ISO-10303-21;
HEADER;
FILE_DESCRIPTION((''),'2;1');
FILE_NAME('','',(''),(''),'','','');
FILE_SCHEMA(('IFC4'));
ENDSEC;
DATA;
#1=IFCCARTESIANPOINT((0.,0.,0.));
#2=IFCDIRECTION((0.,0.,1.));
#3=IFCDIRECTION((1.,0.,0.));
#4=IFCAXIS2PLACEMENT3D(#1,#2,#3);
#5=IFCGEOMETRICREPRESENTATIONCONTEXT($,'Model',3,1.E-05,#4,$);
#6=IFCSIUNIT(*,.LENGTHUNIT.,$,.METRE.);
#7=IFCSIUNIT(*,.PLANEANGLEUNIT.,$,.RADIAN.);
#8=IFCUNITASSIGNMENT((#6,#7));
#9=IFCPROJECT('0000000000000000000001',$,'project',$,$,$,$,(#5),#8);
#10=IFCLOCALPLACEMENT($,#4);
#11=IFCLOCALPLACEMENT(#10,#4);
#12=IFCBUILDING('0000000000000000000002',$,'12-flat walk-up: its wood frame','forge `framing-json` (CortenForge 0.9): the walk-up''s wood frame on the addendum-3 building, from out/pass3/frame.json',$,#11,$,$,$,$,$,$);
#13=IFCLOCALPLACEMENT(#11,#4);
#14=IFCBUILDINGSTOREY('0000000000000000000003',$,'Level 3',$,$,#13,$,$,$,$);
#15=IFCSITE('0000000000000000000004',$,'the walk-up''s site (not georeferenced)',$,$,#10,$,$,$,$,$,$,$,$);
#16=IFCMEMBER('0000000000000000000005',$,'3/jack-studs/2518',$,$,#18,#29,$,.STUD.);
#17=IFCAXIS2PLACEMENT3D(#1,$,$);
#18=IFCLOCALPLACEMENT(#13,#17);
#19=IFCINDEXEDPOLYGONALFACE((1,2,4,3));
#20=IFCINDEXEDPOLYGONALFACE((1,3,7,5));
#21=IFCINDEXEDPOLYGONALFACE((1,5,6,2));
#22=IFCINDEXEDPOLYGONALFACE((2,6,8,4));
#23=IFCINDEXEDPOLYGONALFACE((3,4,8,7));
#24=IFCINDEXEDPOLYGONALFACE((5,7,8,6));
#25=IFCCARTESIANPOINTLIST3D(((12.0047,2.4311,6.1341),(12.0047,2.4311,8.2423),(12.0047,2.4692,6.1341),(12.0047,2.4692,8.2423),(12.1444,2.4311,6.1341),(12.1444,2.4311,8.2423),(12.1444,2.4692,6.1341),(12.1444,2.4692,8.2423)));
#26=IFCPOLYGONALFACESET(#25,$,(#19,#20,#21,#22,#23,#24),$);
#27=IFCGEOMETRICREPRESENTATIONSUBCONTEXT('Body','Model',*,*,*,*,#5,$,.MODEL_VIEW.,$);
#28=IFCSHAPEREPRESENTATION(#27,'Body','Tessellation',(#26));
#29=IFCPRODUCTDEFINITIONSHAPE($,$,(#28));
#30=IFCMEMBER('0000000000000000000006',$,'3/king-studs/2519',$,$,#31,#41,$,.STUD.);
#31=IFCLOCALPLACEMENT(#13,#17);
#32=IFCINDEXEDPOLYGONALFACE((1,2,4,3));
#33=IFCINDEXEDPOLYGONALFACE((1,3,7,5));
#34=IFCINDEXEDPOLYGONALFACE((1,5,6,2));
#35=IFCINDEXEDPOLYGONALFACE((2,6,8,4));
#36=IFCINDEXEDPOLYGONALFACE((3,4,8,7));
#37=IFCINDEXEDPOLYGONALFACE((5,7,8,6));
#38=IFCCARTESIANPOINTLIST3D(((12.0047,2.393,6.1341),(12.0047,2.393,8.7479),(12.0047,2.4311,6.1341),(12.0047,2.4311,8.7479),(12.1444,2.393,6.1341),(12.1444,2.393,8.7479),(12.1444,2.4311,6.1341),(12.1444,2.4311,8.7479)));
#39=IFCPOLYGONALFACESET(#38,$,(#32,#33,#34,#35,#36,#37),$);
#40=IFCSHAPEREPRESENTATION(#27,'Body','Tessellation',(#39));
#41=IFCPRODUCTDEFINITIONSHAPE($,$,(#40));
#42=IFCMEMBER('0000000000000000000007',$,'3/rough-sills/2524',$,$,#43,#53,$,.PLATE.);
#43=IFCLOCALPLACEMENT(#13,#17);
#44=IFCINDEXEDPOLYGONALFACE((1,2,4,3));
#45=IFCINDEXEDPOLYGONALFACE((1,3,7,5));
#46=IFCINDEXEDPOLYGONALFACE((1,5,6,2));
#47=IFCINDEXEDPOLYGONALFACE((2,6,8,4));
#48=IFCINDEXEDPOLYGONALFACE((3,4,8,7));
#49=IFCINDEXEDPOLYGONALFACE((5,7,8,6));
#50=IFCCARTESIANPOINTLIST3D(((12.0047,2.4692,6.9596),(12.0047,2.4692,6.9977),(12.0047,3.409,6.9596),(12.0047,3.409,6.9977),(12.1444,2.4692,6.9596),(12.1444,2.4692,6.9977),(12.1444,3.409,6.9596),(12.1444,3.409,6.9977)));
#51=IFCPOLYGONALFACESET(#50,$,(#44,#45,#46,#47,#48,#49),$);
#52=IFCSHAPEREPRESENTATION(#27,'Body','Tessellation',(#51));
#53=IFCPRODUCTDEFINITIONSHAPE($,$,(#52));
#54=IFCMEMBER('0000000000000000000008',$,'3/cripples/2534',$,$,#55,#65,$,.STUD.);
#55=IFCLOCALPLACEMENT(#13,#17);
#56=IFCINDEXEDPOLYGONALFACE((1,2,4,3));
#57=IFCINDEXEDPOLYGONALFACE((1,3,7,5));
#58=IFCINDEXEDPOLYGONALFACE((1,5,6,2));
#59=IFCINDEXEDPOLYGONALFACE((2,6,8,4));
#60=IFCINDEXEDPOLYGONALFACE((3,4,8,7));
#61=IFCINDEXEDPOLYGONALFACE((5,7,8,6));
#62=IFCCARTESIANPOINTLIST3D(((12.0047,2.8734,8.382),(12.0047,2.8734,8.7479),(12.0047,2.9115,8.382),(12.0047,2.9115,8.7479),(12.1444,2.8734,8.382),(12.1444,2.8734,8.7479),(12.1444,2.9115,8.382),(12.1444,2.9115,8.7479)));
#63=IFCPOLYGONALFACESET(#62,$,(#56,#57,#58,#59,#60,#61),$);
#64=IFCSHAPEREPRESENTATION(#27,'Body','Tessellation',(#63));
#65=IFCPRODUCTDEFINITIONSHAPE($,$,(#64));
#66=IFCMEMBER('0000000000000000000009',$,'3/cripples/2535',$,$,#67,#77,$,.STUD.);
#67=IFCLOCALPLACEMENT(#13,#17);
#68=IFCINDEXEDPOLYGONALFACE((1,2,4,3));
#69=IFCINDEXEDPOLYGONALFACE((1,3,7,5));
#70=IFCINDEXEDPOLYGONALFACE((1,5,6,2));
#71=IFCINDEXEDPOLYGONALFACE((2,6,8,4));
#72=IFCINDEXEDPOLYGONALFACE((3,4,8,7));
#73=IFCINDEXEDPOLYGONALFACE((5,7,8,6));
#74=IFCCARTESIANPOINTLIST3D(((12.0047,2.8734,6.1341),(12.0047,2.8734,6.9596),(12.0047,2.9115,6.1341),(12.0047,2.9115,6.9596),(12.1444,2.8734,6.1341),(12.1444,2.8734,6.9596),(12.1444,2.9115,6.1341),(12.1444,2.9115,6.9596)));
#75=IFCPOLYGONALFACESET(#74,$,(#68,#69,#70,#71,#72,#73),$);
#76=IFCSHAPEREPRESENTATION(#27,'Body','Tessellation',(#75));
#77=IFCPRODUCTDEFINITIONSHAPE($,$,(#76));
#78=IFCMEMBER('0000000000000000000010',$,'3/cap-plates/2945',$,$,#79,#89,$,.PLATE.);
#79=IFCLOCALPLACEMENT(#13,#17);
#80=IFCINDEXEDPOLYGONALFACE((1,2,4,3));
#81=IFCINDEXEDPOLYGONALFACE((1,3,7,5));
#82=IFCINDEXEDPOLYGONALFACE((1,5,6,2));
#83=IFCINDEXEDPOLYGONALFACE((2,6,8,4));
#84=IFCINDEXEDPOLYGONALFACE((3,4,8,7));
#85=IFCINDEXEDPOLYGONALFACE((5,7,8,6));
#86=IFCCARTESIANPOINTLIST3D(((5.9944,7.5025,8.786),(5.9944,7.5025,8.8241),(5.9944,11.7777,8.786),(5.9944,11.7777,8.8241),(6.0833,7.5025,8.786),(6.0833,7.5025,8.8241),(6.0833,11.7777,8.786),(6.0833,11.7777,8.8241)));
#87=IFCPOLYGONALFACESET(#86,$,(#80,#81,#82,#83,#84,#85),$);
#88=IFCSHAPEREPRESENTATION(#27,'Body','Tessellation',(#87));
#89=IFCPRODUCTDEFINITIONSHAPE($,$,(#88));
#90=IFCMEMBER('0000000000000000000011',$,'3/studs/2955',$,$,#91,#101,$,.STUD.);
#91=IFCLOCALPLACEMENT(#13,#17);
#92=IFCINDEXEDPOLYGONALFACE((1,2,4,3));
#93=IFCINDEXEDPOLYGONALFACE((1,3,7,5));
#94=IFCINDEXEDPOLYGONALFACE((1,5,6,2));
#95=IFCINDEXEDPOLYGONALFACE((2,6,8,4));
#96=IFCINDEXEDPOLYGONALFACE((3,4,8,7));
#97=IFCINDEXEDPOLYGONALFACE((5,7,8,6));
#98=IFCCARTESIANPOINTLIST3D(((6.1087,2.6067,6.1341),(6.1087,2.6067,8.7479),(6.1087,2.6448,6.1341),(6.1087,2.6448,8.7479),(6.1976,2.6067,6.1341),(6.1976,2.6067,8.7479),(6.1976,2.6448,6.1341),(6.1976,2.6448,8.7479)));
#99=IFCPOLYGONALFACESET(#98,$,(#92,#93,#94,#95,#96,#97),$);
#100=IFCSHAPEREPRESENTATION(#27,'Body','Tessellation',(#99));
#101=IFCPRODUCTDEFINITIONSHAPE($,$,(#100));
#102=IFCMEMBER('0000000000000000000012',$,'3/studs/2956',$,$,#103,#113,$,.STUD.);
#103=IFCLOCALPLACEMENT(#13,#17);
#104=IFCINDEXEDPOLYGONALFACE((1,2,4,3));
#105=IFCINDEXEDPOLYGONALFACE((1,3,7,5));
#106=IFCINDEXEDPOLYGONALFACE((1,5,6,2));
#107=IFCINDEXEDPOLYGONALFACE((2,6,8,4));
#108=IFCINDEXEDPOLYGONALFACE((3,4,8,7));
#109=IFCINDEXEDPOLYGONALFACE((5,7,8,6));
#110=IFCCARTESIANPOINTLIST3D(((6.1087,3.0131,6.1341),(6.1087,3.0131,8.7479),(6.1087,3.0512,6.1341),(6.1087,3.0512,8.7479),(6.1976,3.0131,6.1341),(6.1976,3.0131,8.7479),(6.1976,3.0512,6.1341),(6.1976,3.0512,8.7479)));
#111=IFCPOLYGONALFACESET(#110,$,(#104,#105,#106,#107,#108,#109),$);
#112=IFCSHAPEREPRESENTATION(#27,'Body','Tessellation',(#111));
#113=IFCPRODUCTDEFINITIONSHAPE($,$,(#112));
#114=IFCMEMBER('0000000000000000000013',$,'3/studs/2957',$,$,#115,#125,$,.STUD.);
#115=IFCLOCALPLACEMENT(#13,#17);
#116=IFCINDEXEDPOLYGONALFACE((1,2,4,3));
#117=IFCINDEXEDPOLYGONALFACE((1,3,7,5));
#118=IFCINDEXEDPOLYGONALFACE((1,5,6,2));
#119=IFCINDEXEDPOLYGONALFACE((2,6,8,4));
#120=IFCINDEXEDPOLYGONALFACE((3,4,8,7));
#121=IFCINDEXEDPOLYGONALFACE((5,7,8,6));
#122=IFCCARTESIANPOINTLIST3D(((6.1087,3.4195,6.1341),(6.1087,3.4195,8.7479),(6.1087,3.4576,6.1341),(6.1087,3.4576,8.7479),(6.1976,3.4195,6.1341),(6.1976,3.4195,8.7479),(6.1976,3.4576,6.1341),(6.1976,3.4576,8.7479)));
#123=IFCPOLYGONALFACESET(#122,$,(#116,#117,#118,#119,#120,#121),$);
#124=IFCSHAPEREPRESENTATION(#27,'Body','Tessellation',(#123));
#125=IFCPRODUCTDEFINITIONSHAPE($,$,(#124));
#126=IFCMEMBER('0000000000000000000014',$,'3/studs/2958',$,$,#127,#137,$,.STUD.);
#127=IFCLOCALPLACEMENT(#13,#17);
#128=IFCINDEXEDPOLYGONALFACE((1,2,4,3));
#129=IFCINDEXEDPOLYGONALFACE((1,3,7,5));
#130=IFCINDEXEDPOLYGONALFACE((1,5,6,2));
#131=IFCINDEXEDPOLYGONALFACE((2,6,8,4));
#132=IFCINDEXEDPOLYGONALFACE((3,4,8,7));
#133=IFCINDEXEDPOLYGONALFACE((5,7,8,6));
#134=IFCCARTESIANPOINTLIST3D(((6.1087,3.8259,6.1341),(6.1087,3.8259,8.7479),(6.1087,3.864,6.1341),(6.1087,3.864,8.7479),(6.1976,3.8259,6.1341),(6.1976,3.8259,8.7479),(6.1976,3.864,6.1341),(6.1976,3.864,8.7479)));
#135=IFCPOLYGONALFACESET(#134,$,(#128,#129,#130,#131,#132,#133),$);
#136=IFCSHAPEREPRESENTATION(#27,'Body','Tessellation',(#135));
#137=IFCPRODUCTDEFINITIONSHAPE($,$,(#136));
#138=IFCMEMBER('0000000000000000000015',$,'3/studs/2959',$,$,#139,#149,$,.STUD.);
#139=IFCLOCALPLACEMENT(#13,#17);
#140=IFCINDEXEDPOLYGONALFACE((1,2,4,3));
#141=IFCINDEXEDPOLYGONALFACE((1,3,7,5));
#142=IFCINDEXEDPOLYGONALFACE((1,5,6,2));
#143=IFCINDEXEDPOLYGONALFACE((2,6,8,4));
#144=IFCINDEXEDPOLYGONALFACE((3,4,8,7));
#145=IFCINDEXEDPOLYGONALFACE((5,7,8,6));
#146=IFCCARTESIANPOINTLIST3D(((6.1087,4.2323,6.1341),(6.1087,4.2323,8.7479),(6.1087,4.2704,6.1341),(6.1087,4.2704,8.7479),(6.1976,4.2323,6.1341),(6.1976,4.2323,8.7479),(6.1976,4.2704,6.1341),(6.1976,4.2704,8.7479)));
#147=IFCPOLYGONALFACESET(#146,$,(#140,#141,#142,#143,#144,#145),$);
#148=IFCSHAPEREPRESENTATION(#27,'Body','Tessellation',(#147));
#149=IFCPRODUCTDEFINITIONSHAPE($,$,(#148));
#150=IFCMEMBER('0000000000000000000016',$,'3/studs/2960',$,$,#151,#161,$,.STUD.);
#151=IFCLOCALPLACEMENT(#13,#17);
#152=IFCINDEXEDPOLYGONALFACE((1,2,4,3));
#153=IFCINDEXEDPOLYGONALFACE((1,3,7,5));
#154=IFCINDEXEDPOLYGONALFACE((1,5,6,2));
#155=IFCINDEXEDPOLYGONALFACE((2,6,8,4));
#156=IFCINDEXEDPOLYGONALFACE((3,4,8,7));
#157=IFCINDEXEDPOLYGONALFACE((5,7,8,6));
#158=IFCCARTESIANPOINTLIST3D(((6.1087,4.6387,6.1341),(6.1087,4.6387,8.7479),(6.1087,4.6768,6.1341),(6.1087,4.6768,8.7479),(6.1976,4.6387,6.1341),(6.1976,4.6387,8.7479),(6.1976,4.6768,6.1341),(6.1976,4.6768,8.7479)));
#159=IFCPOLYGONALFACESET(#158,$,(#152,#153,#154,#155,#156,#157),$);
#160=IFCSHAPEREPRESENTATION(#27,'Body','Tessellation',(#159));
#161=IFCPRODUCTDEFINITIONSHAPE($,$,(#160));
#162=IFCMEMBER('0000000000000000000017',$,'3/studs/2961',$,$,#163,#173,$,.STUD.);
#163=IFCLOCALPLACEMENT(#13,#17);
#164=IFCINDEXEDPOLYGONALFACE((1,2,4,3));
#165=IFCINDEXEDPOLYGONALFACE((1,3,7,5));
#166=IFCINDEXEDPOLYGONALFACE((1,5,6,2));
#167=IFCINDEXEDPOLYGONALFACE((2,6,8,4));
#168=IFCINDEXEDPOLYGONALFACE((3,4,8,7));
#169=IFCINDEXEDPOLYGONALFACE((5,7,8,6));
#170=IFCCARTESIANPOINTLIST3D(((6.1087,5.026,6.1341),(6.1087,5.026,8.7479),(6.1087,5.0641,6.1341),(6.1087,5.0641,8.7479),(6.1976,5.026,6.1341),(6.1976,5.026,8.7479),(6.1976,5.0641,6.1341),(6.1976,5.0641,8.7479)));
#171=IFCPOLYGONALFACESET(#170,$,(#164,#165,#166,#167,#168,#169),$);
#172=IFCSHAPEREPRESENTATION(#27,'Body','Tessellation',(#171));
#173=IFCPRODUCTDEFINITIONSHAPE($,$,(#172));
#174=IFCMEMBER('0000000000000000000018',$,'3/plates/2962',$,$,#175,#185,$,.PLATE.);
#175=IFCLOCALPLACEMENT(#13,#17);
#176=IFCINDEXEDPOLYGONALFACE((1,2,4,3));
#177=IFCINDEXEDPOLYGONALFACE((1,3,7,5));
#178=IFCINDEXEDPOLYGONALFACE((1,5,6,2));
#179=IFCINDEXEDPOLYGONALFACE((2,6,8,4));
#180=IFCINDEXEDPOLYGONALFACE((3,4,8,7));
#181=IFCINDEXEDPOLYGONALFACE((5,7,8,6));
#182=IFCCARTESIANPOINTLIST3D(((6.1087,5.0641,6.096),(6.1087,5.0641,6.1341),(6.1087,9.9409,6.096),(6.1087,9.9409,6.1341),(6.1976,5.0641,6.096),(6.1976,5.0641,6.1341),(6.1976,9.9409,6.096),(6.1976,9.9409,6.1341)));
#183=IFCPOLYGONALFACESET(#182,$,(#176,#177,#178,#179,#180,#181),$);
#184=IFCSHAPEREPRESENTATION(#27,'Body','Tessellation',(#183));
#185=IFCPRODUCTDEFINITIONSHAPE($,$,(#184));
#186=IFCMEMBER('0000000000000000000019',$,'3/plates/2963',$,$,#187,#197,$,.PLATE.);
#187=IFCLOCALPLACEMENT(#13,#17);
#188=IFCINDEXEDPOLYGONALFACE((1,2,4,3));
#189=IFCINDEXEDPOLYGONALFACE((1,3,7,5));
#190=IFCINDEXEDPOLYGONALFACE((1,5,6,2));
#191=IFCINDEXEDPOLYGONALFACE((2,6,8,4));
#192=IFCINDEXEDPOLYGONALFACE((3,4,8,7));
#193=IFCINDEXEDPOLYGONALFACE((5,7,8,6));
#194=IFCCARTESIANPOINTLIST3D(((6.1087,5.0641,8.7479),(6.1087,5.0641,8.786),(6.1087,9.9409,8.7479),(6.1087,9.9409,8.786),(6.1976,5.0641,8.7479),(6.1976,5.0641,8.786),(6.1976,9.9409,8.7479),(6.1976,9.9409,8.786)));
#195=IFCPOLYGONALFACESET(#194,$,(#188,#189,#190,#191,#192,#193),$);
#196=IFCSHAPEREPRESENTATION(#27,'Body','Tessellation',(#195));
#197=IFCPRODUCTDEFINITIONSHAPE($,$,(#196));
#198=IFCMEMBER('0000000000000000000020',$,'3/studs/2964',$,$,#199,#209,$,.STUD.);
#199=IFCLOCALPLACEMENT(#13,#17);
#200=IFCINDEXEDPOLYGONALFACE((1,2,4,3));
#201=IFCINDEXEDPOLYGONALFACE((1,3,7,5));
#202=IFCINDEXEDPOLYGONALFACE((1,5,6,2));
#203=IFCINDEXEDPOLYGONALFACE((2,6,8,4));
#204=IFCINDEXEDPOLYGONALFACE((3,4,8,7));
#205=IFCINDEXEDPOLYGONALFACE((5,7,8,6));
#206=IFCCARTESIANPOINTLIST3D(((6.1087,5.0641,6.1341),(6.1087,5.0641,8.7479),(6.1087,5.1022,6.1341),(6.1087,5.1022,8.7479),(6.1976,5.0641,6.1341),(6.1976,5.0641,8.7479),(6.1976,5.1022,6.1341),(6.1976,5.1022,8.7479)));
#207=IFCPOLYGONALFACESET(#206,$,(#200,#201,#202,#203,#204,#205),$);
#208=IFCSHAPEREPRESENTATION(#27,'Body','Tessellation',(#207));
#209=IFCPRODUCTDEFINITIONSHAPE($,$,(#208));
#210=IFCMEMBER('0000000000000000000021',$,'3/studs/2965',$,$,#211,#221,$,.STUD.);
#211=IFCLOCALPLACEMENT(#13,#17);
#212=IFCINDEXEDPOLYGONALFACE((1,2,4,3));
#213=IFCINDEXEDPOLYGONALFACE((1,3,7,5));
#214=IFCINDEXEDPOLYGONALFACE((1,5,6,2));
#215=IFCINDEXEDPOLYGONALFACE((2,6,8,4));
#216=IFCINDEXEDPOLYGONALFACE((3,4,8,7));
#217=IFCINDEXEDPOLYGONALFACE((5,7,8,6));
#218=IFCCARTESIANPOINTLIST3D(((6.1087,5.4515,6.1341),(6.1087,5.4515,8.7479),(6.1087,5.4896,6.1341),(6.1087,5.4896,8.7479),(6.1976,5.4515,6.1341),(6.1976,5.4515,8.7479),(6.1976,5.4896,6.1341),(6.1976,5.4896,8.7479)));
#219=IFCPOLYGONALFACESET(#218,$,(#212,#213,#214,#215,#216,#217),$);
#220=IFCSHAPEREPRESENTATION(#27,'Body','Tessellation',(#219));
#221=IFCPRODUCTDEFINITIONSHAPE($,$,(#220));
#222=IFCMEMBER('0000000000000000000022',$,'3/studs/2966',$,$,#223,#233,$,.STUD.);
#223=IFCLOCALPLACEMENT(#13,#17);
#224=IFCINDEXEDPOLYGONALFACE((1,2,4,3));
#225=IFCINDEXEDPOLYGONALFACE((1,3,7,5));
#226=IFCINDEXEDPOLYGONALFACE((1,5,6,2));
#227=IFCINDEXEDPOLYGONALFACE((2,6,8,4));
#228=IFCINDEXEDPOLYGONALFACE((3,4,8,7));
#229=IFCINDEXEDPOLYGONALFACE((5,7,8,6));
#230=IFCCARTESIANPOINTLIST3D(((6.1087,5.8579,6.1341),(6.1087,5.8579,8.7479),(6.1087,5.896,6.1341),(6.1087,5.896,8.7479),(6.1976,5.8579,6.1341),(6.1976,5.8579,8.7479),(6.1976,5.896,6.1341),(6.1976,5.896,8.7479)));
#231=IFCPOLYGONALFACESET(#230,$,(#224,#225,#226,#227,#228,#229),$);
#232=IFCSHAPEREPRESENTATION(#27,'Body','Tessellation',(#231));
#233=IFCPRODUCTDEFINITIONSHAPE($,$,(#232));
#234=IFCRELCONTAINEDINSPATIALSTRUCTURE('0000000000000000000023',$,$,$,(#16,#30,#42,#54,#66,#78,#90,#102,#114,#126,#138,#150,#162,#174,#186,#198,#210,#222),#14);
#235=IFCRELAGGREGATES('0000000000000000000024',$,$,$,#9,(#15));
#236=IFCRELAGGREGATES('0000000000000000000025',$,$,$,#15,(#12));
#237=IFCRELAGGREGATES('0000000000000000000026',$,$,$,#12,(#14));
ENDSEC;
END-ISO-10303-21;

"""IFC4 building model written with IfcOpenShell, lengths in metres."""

from ifc_helpers import new_model, si_unit, frame, frame_2d, origin, origin_with_axes, place, context, subcontext, project, spatial, rectangle, extrude, element, save


model = new_model("IFC4")

# Units and contexts
model_context = context("Model", 3, precision=1e-05, world=origin_with_axes())
body_context = subcontext(model_context, "Body", "Model", "MODEL_VIEW")
ifc_project = project(units=[si_unit("LENGTHUNIT", "METRE"), si_unit("PLANEANGLEUNIT", "RADIAN")], contexts=[model_context])

# Site, building, storey
site_placement = place(None, origin_with_axes())
site = spatial("IfcSite", under=ifc_project, at=site_placement, Name="the walk-up's site (not georeferenced)")
building_placement = place(site_placement, origin_with_axes())
building = spatial("IfcBuilding", under=site, at=building_placement, Name="12-flat walk-up: its wood frame", Description="forge `framing-json` (CortenForge 0.9): the walk-up's wood frame on the addendum-3 building, from out/pass3/frame.json")
storey_placement = place(building_placement, origin_with_axes())
storey = spatial("IfcBuildingStorey", under=building, at=storey_placement, Name="Level 3")

# Members
member_1_placement = place(storey_placement, frame((12.0047, 2.4311, 6.1341), z_axis=(0.0, 0.0, 1.0), x_axis=(1.0, 0.0, 0.0)))
element("IfcMember", 1, at=member_1_placement, inside=storey, Name="3/jack-studs/2518", PredefinedType="STUD", context=body_context, shape_type="SweptSolid", body=[
    extrude(rectangle(XDim=0.1397, YDim=0.0381, at=frame_2d((0.0698, 0.0191))), origin(), (0.0, 0.0, 1.0), 2.1082),
])
member_2_placement = place(storey_placement, frame((12.0047, 2.393, 6.1341), z_axis=(0.0, 0.0, 1.0), x_axis=(1.0, 0.0, 0.0)))
element("IfcMember", 2, at=member_2_placement, inside=storey, Name="3/king-studs/2519", PredefinedType="STUD", context=body_context, shape_type="SweptSolid", body=[
    extrude(rectangle(XDim=0.1397, YDim=0.0381, at=frame_2d((0.0698, 0.0191))), origin(), (0.0, 0.0, 1.0), 2.6138),
])
member_3_placement = place(storey_placement, frame((12.0047, 2.4692, 6.9596), z_axis=(0.0, 0.0, 1.0), x_axis=(1.0, 0.0, 0.0)))
element("IfcMember", 3, at=member_3_placement, inside=storey, Name="3/rough-sills/2524", PredefinedType="PLATE", context=body_context, shape_type="SweptSolid", body=[
    extrude(rectangle(XDim=0.1397, YDim=0.9398, at=frame_2d((0.0698, 0.4699))), origin(), (0.0, 0.0, 1.0), 0.0381),
])
member_4_placement = place(storey_placement, frame((12.0047, 2.8734, 8.382), z_axis=(0.0, 0.0, 1.0), x_axis=(1.0, 0.0, 0.0)))
element("IfcMember", 4, at=member_4_placement, inside=storey, Name="3/cripples/2534", PredefinedType="STUD", context=body_context, shape_type="SweptSolid", body=[
    extrude(rectangle(XDim=0.1397, YDim=0.0381, at=frame_2d((0.0698, 0.0191))), origin(), (0.0, 0.0, 1.0), 0.3659),
])
member_5_placement = place(storey_placement, frame((12.0047, 2.8734, 6.1341), z_axis=(0.0, 0.0, 1.0), x_axis=(1.0, 0.0, 0.0)))
element("IfcMember", 5, at=member_5_placement, inside=storey, Name="3/cripples/2535", PredefinedType="STUD", context=body_context, shape_type="SweptSolid", body=[
    extrude(rectangle(XDim=0.1397, YDim=0.0381, at=frame_2d((0.0698, 0.0191))), origin(), (0.0, 0.0, 1.0), 0.8255),
])
member_6_placement = place(storey_placement, frame((5.9944, 7.5025, 8.786), z_axis=(0.0, 0.0, 1.0), x_axis=(1.0, 0.0, 0.0)))
element("IfcMember", 6, at=member_6_placement, inside=storey, Name="3/cap-plates/2945", PredefinedType="PLATE", context=body_context, shape_type="SweptSolid", body=[
    extrude(rectangle(XDim=0.0889, YDim=4.2751, at=frame_2d((0.0445, 2.1376))), origin(), (0.0, 0.0, 1.0), 0.0381),
])
for number, where, z_axis, x_axis, name in (
    (7, (6.1087, 2.6067, 6.1341), (0.0, 0.0, 1.0), (1.0, 0.0, 0.0), "3/studs/2955"),
    (8, (6.1087, 3.0131, 6.1341), (0.0, 0.0, 1.0), (1.0, 0.0, 0.0), "3/studs/2956"),
    (9, (6.1087, 3.4195, 6.1341), (0.0, 0.0, 1.0), (1.0, 0.0, 0.0), "3/studs/2957"),
    (10, (6.1087, 3.8259, 6.1341), (0.0, 0.0, 1.0), (1.0, 0.0, 0.0), "3/studs/2958"),
    (11, (6.1087, 4.2323, 6.1341), (0.0, 0.0, 1.0), (1.0, 0.0, 0.0), "3/studs/2959"),
    (12, (6.1087, 4.6387, 6.1341), (0.0, 0.0, 1.0), (1.0, 0.0, 0.0), "3/studs/2960"),
    (13, (6.1087, 5.026, 6.1341), (0.0, 0.0, 1.0), (1.0, 0.0, 0.0), "3/studs/2961"),
):
    element("IfcMember", number, at=place(storey_placement, frame(where, z_axis=z_axis, x_axis=x_axis)), inside=storey, Name=name, PredefinedType="STUD", context=body_context, shape_type="SweptSolid", body=[
        extrude(rectangle(XDim=0.0889, YDim=0.0381, at=frame_2d((0.0445, 0.0191))), origin(), (0.0, 0.0, 1.0), 2.6138),
    ])
for number, where, z_axis, x_axis, name in (
    (14, (6.1087, 5.0641, 6.096), (0.0, 0.0, 1.0), (1.0, 0.0, 0.0), "3/plates/2962"),
    (15, (6.1087, 5.0641, 8.7479), (0.0, 0.0, 1.0), (1.0, 0.0, 0.0), "3/plates/2963"),
):
    element("IfcMember", number, at=place(storey_placement, frame(where, z_axis=z_axis, x_axis=x_axis)), inside=storey, Name=name, PredefinedType="PLATE", context=body_context, shape_type="SweptSolid", body=[
        extrude(rectangle(XDim=0.0889, YDim=4.8768, at=frame_2d((0.0445, 2.4384))), origin(), (0.0, 0.0, 1.0), 0.0381),
    ])
for number, where, z_axis, x_axis, name in (
    (16, (6.1087, 5.0641, 6.1341), (0.0, 0.0, 1.0), (1.0, 0.0, 0.0), "3/studs/2964"),
    (17, (6.1087, 5.4515, 6.1341), (0.0, 0.0, 1.0), (1.0, 0.0, 0.0), "3/studs/2965"),
    (18, (6.1087, 5.8579, 6.1341), (0.0, 0.0, 1.0), (1.0, 0.0, 0.0), "3/studs/2966"),
):
    element("IfcMember", number, at=place(storey_placement, frame(where, z_axis=z_axis, x_axis=x_axis)), inside=storey, Name=name, PredefinedType="STUD", context=body_context, shape_type="SweptSolid", body=[
        extrude(rectangle(XDim=0.0889, YDim=0.0381, at=frame_2d((0.0445, 0.0191))), origin(), (0.0, 0.0, 1.0), 2.6138),
    ])

save(model, "model.ifc")
